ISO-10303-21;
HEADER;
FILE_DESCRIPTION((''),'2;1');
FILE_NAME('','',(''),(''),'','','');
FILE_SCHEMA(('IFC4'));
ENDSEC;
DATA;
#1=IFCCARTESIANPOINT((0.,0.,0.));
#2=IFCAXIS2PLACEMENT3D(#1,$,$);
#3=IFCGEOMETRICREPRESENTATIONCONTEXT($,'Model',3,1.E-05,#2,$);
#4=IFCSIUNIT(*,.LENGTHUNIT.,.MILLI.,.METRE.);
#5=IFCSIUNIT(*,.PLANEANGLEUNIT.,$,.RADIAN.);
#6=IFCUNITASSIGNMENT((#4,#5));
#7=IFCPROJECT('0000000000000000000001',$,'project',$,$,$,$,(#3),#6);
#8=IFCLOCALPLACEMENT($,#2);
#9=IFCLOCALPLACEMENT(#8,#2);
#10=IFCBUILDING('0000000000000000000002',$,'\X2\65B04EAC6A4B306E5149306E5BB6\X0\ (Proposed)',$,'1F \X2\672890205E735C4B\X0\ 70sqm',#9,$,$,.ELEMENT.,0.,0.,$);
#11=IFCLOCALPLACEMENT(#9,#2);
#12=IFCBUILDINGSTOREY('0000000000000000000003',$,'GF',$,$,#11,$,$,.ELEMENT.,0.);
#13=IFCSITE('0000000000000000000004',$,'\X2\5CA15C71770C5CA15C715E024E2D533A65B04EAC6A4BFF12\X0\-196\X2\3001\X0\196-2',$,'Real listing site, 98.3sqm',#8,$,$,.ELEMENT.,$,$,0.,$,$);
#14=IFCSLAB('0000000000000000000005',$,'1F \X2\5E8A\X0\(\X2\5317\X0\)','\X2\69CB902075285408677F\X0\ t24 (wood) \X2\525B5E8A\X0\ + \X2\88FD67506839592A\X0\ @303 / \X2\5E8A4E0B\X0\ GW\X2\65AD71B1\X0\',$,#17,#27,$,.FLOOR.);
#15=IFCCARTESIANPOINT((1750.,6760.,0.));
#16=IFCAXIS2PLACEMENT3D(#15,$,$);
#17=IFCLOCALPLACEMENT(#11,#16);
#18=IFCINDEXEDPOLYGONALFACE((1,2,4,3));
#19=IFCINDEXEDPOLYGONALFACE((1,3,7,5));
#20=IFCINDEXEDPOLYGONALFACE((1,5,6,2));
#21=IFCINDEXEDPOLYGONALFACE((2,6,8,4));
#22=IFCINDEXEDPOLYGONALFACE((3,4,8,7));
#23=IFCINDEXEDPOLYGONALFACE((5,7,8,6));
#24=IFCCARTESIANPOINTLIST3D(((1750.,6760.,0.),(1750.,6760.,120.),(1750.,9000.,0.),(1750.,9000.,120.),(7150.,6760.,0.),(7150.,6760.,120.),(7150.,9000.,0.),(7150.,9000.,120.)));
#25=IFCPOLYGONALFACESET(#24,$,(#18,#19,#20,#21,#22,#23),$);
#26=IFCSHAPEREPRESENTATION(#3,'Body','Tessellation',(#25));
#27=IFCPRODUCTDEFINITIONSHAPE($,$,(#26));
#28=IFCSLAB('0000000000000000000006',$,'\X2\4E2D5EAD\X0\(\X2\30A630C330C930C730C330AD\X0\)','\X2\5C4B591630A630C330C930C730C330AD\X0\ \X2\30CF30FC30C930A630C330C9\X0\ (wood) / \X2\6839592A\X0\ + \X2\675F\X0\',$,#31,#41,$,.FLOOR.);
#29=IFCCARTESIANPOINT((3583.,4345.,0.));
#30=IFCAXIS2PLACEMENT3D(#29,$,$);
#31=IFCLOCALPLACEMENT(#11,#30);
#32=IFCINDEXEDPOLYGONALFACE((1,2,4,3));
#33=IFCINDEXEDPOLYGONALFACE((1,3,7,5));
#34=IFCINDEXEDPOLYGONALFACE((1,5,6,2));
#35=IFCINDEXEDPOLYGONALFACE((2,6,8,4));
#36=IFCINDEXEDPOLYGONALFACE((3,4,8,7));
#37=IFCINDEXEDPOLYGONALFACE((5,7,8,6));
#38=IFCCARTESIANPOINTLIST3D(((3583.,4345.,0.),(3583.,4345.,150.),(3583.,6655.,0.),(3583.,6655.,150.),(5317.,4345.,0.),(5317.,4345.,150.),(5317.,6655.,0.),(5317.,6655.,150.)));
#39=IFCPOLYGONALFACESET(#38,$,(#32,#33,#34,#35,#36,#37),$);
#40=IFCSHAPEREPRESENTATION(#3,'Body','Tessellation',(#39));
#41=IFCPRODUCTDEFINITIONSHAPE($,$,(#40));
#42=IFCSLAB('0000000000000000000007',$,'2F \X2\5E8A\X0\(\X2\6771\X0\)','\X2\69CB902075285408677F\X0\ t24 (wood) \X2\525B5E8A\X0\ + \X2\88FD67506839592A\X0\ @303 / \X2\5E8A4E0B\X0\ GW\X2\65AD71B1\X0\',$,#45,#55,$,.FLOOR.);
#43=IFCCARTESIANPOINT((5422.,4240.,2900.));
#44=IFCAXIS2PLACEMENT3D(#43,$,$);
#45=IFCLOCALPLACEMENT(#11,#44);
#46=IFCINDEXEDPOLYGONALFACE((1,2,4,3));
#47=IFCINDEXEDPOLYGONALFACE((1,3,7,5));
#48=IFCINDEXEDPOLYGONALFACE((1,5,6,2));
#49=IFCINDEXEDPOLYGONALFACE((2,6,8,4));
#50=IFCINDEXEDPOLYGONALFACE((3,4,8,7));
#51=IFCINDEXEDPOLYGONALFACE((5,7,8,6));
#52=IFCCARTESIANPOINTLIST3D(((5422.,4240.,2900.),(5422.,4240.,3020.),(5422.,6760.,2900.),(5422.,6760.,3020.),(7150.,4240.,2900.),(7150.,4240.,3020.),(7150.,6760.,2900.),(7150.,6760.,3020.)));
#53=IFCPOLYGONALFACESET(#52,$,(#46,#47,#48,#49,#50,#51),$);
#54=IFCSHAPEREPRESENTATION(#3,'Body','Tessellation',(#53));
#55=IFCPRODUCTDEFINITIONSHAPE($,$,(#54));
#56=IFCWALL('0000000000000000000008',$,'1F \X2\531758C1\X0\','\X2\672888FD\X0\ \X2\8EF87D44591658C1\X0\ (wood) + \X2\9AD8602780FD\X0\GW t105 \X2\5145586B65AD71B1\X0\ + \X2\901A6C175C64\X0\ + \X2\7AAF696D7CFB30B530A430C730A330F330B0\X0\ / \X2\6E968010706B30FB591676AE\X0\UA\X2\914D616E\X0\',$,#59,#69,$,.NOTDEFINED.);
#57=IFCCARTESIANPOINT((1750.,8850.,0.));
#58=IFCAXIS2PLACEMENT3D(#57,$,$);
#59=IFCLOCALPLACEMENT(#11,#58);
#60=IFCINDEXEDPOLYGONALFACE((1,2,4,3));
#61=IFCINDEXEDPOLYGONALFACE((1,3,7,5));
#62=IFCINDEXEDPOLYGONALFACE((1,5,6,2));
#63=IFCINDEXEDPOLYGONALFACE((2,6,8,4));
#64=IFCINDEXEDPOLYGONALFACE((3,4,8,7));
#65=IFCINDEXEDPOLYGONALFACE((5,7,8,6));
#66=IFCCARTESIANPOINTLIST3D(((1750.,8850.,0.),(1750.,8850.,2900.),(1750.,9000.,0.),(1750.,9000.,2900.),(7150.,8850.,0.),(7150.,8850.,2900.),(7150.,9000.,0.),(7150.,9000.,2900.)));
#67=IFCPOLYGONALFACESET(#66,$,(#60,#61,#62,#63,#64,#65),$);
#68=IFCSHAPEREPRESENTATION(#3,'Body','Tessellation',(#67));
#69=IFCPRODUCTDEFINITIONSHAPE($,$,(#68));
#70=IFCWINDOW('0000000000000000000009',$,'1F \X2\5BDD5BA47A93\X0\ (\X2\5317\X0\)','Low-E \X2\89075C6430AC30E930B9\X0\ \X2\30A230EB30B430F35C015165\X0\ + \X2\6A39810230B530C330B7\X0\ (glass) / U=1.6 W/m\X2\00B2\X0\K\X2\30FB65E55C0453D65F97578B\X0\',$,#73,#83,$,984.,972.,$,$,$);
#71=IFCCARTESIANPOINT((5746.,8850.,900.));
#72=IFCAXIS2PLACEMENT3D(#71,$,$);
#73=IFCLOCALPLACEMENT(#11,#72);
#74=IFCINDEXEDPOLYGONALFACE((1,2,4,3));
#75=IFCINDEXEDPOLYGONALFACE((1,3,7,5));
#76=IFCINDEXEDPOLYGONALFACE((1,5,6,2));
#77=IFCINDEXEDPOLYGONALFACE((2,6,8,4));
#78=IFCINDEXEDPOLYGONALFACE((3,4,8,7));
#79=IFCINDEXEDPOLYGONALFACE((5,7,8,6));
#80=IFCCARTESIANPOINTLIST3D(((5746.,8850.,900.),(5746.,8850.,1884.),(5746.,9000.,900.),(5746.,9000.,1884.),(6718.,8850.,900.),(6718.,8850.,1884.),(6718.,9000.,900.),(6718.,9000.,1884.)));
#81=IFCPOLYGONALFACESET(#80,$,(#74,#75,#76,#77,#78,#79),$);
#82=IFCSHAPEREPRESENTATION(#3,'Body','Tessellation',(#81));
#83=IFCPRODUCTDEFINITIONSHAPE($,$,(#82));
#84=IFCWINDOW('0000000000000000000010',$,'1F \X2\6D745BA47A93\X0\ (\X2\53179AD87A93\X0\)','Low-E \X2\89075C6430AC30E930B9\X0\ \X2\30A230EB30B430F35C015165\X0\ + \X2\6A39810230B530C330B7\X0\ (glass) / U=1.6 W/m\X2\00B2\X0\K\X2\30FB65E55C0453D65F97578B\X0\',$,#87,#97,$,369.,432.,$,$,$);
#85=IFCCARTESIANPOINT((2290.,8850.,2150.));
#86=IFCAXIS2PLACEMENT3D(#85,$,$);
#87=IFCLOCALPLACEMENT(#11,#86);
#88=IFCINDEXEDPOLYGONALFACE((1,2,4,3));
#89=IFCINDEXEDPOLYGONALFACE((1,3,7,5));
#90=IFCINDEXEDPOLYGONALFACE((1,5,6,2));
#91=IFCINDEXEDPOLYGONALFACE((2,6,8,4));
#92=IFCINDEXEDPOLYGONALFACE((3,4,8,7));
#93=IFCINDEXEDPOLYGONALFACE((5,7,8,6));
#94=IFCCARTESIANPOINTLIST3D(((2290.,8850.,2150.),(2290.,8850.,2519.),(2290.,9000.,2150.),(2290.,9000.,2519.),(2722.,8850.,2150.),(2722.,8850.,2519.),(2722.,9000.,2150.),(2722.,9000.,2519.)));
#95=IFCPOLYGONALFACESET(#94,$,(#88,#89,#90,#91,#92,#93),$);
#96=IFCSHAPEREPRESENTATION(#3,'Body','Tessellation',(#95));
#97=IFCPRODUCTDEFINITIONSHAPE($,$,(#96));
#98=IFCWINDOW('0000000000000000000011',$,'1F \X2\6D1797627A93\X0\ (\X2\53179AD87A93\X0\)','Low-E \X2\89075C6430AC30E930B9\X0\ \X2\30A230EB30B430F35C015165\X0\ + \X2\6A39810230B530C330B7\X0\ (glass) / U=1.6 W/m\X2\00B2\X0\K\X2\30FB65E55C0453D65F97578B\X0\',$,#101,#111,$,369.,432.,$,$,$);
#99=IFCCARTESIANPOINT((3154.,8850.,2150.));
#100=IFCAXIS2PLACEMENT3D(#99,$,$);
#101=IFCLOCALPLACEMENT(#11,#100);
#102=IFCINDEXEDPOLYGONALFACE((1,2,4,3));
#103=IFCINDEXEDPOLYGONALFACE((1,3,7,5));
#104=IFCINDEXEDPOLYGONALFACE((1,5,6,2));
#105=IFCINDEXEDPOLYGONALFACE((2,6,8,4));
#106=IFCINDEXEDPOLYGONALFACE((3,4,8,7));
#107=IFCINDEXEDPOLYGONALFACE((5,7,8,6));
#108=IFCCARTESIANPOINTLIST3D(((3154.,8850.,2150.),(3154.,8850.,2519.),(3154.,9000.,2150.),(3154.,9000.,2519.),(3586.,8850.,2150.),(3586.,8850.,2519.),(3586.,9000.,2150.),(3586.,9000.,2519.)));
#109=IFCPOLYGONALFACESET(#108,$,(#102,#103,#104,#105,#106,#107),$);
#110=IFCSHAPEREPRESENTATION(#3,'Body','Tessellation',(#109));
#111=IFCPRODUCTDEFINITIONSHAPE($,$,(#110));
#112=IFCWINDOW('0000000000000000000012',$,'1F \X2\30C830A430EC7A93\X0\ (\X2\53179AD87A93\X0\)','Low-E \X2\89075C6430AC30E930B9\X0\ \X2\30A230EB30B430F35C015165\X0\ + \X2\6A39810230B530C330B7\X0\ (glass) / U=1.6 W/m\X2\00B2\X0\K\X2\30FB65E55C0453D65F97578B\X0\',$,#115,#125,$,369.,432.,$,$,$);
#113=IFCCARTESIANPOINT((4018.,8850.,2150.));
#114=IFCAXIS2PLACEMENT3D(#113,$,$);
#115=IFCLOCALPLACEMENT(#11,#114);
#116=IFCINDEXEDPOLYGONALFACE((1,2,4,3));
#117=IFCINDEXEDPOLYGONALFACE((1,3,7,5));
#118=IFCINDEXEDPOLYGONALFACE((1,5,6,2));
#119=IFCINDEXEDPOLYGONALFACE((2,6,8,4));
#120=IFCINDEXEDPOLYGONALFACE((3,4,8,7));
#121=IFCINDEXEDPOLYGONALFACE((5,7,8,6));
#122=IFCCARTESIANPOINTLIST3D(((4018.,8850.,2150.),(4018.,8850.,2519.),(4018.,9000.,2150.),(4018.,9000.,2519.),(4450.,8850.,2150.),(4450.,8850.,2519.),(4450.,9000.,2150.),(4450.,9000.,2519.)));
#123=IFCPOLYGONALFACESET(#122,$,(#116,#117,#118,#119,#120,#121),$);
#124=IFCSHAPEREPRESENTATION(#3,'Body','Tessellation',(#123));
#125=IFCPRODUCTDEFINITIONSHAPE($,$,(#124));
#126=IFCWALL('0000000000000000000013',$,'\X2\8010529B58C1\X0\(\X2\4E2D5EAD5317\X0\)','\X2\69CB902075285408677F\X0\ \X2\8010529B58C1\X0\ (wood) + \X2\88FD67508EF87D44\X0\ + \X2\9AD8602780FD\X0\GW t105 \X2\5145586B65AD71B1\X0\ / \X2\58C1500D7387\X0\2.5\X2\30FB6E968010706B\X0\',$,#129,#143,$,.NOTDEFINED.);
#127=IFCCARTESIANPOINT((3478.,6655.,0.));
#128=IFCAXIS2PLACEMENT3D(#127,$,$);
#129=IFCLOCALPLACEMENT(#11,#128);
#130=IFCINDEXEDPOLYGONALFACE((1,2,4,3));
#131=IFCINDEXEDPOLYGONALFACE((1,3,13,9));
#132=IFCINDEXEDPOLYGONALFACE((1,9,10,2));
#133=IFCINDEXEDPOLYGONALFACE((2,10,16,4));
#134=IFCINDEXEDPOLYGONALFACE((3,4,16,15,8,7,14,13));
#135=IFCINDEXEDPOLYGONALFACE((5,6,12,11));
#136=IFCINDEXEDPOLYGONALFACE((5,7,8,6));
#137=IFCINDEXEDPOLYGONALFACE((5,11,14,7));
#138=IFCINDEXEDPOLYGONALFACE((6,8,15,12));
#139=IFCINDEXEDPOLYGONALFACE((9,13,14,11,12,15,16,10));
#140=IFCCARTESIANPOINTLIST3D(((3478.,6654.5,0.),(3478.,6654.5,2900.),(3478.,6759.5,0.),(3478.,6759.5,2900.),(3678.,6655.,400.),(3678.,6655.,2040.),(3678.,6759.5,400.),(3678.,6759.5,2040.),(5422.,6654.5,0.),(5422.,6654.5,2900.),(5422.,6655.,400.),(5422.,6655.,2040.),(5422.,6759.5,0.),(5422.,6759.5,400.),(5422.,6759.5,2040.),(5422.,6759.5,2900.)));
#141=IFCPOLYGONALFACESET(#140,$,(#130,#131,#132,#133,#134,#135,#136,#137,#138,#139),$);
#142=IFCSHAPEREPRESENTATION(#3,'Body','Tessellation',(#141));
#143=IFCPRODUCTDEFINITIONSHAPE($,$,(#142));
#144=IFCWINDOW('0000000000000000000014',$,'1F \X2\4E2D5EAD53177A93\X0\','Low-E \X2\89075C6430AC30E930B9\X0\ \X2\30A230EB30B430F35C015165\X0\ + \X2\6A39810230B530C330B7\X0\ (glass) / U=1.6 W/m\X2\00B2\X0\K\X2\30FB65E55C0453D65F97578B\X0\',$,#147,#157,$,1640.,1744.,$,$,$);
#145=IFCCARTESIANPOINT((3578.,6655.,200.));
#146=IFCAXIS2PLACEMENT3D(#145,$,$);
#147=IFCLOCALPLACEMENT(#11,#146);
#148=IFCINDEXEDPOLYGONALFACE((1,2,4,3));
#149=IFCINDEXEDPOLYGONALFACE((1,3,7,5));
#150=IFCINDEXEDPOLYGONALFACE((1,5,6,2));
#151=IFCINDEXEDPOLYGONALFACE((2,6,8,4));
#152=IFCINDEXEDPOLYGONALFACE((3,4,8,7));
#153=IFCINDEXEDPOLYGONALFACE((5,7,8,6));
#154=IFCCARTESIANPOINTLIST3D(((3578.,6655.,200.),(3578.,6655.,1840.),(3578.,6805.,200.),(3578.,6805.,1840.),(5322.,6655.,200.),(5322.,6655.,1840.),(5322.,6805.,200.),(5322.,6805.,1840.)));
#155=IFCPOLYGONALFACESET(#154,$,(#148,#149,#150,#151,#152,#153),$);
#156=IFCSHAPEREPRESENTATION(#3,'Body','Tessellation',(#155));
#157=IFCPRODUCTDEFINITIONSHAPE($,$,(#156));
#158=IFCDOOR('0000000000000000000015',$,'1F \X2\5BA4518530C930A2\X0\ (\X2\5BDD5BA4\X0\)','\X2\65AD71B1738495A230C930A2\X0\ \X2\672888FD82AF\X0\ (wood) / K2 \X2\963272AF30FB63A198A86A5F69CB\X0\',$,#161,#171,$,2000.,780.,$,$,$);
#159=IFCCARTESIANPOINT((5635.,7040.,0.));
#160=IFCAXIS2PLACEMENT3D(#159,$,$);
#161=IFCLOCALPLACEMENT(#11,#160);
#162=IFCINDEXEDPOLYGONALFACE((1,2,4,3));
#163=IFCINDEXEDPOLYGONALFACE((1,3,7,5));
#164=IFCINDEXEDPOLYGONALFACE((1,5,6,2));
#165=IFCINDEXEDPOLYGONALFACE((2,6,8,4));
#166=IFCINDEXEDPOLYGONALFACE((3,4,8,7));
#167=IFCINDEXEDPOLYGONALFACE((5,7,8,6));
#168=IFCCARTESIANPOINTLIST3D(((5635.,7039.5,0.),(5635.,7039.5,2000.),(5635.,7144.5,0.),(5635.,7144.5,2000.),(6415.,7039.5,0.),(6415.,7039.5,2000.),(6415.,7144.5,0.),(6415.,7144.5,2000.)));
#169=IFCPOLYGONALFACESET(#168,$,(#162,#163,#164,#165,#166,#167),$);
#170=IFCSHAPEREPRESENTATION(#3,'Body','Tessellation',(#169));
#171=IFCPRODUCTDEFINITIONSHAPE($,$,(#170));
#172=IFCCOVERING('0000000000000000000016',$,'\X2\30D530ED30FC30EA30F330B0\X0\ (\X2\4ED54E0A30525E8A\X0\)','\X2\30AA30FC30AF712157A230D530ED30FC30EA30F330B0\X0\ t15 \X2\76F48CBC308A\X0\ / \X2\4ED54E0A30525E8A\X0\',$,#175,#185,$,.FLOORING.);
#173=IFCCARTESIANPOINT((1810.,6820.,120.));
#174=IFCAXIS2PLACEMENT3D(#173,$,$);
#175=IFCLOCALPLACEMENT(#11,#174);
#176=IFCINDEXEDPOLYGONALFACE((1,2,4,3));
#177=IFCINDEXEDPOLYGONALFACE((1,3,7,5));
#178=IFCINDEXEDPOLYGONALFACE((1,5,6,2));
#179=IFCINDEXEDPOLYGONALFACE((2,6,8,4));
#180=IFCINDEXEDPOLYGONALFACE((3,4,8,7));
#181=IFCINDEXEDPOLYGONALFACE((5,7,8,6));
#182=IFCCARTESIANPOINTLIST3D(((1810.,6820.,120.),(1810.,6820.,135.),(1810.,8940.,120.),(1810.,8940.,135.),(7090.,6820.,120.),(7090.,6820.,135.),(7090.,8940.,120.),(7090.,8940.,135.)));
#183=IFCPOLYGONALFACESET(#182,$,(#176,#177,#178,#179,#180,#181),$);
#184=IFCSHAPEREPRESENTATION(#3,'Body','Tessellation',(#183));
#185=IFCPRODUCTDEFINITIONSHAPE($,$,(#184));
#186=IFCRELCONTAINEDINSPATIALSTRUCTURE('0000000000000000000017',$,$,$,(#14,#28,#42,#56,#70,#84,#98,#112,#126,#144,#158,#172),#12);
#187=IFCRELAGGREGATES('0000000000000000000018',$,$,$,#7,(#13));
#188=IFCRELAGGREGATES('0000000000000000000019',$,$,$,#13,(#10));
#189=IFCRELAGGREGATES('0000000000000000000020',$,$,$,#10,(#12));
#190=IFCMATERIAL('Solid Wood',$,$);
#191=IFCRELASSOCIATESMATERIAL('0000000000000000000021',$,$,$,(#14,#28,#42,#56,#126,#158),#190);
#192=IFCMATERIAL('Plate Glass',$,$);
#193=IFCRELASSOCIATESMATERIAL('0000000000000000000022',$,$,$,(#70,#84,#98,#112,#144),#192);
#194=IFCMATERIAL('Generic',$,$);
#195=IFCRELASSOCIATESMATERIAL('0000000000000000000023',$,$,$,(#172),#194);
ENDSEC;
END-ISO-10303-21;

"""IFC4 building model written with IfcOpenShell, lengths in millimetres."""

from ifc_helpers import new_model, si_unit, frame, frame_2d, origin, place, context, project, spatial, rectangle, extrude, material, element, fill, save


model = new_model("IFC4")

# Units and contexts
model_context = context("Model", 3, precision=1e-05, world=origin())
ifc_project = project(units=[si_unit("LENGTHUNIT", "METRE", prefix="MILLI"), si_unit("PLANEANGLEUNIT", "RADIAN")], contexts=[model_context])

# Site, building, storey
site_placement = place(None, origin())
site = spatial("IfcSite", under=ifc_project, at=site_placement, Name="岡山県岡山市中区新京橋２-196、196-2", ObjectType="Real listing site, 98.3sqm", CompositionType="ELEMENT", RefElevation=0.0)
building_placement = place(site_placement, origin())
building = spatial("IfcBuilding", under=site, at=building_placement, Name="新京橋の光の家 (Proposed)", ObjectType="1F 木造平屋 70sqm", CompositionType="ELEMENT", ElevationOfRefHeight=0.0, ElevationOfTerrain=0.0)
storey_placement = place(building_placement, origin())
storey = spatial("IfcBuildingStorey", under=building, at=storey_placement, Name="GF", CompositionType="ELEMENT", Elevation=0.0)

# Slabs
ifc_material_1 = material(Name="Solid Wood")
slab_1_placement = place(storey_placement, frame((1750.0, 6760.0, 0.0)))
element("IfcSlab", 1, at=slab_1_placement, inside=storey, material=ifc_material_1, Name="1F 床(北)", Description="構造用合板 t24 (wood) 剛床 + 製材根太 @303 / 床下 GW断熱", PredefinedType="FLOOR", context=model_context, shape_type="SweptSolid", body=[
    extrude(rectangle(XDim=5400.0, YDim=2240.0, at=frame_2d((2700.0, 1120.0))), frame((1750.0, 6760.0, 0.0)), (0.0, 0.0, 1.0), 120.0),
])
slab_2_placement = place(storey_placement, frame((3583.0, 4345.0, 0.0)))
element("IfcSlab", 2, at=slab_2_placement, inside=storey, material=ifc_material_1, Name="中庭(ウッドデッキ)", Description="屋外ウッドデッキ ハードウッド (wood) / 根太 + 束", PredefinedType="FLOOR", context=model_context, shape_type="SweptSolid", body=[
    extrude(rectangle(XDim=1734.0, YDim=2310.0, at=frame_2d((867.0, 1155.0))), frame((3583.0, 4345.0, 0.0)), (0.0, 0.0, 1.0), 150.0),
])
slab_3_placement = place(storey_placement, frame((5422.0, 4240.0, 2900.0)))
element("IfcSlab", 3, at=slab_3_placement, inside=storey, material=ifc_material_1, Name="2F 床(東)", Description="構造用合板 t24 (wood) 剛床 + 製材根太 @303 / 床下 GW断熱", PredefinedType="FLOOR", context=model_context, shape_type="SweptSolid", body=[
    extrude(rectangle(XDim=1728.0, YDim=2520.0, at=frame_2d((864.0, 1260.0))), frame((5422.0, 4240.0, 2900.0)), (0.0, 0.0, 1.0), 120.0),
])

# Wall, openings, windows
wall_1_placement = place(storey_placement, frame((1750.0, 8850.0, 0.0)))
wall_1 = element("IfcWall", 4, at=wall_1_placement, inside=storey, material=ifc_material_1, Name="1F 北壁", Description="木製 軸組外壁 (wood) + 高性能GW t105 充填断熱 + 通気層 + 窯業系サイディング / 準耐火・外皮UA配慮", PredefinedType="NOTDEFINED", context=model_context, shape_type="SweptSolid", body=[
    extrude(rectangle(XDim=5400.0, YDim=150.0, at=frame_2d((2700.0, 75.0))), frame((1750.0, 8850.0, 0.0)), (0.0, 0.0, 1.0), 2900.0),
])
opening_1_placement = place(storey_placement, frame((5746.0, 8850.0, 900.0)))
opening_1 = element("IfcOpeningElement", 5, at=opening_1_placement, cuts=wall_1, PredefinedType="NOTDEFINED", context=model_context, shape_type="SweptSolid", body=[
    extrude(rectangle(XDim=972.0, YDim=150.0, at=frame_2d((486.0, 75.0))), frame((5746.0, 8850.0, 900.0)), (0.0, 0.0, 1.0), 984.0),
])
opening_2_placement = place(storey_placement, frame((2290.0, 8850.0, 2150.0)))
opening_2 = element("IfcOpeningElement", 6, at=opening_2_placement, cuts=wall_1, PredefinedType="NOTDEFINED", context=model_context, shape_type="SweptSolid", body=[
    extrude(rectangle(XDim=432.0, YDim=150.0, at=frame_2d((216.0, 75.0))), frame((2290.0, 8850.0, 2150.0)), (0.0, 0.0, 1.0), 369.0),
])
opening_3_placement = place(storey_placement, frame((3154.0, 8850.0, 2150.0)))
opening_3 = element("IfcOpeningElement", 7, at=opening_3_placement, cuts=wall_1, PredefinedType="NOTDEFINED", context=model_context, shape_type="SweptSolid", body=[
    extrude(rectangle(XDim=432.0, YDim=150.0, at=frame_2d((216.0, 75.0))), frame((3154.0, 8850.0, 2150.0)), (0.0, 0.0, 1.0), 369.0),
])
opening_4_placement = place(storey_placement, frame((4018.0, 8850.0, 2150.0)))
opening_4 = element("IfcOpeningElement", 8, at=opening_4_placement, cuts=wall_1, PredefinedType="NOTDEFINED", context=model_context, shape_type="SweptSolid", body=[
    extrude(rectangle(XDim=432.0, YDim=150.0, at=frame_2d((216.0, 75.0))), frame((4018.0, 8850.0, 2150.0)), (0.0, 0.0, 1.0), 369.0),
])
ifc_material_2 = material(Name="Plate Glass")
window_1_placement = place(storey_placement, frame((5746.0, 8850.0, 900.0)))
window_1 = element("IfcWindow", 9, at=window_1_placement, inside=storey, material=ifc_material_2, Name="1F 寝室窓 (北)", Description="Low-E 複層ガラス アルゴン封入 + 樹脂サッシ (glass) / U=1.6 W/m²K・日射取得型", OverallHeight=984.0, OverallWidth=972.0, context=model_context, shape_type="SweptSolid", body=[
    extrude(rectangle(XDim=972.0, YDim=150.0, at=frame_2d((486.0, 75.0))), frame((5746.0, 8850.0, 900.0)), (0.0, 0.0, 1.0), 984.0),
])
fill(opening_1, window_1)
window_2_placement = place(storey_placement, frame((2290.0, 8850.0, 2150.0)))
window_2 = element("IfcWindow", 10, at=window_2_placement, inside=storey, material=ifc_material_2, Name="1F 浴室窓 (北高窓)", Description="Low-E 複層ガラス アルゴン封入 + 樹脂サッシ (glass) / U=1.6 W/m²K・日射取得型", OverallHeight=369.0, OverallWidth=432.0, context=model_context, shape_type="SweptSolid", body=[
    extrude(rectangle(XDim=432.0, YDim=150.0, at=frame_2d((216.0, 75.0))), frame((2290.0, 8850.0, 2150.0)), (0.0, 0.0, 1.0), 369.0),
])
fill(opening_2, window_2)
window_3_placement = place(storey_placement, frame((3154.0, 8850.0, 2150.0)))
window_3 = element("IfcWindow", 11, at=window_3_placement, inside=storey, material=ifc_material_2, Name="1F 洗面窓 (北高窓)", Description="Low-E 複層ガラス アルゴン封入 + 樹脂サッシ (glass) / U=1.6 W/m²K・日射取得型", OverallHeight=369.0, OverallWidth=432.0, context=model_context, shape_type="SweptSolid", body=[
    extrude(rectangle(XDim=432.0, YDim=150.0, at=frame_2d((216.0, 75.0))), frame((3154.0, 8850.0, 2150.0)), (0.0, 0.0, 1.0), 369.0),
])
fill(opening_3, window_3)
window_4_placement = place(storey_placement, frame((4018.0, 8850.0, 2150.0)))
window_4 = element("IfcWindow", 12, at=window_4_placement, inside=storey, material=ifc_material_2, Name="1F トイレ窓 (北高窓)", Description="Low-E 複層ガラス アルゴン封入 + 樹脂サッシ (glass) / U=1.6 W/m²K・日射取得型", OverallHeight=369.0, OverallWidth=432.0, context=model_context, shape_type="SweptSolid", body=[
    extrude(rectangle(XDim=432.0, YDim=150.0, at=frame_2d((216.0, 75.0))), frame((4018.0, 8850.0, 2150.0)), (0.0, 0.0, 1.0), 369.0),
])
fill(opening_4, window_4)

# Wall, opening, window
wall_2_placement = place(storey_placement, frame((3478.0, 6655.0, 0.0)))
wall_2 = element("IfcWall", 13, at=wall_2_placement, inside=storey, material=ifc_material_1, Name="耐力壁(中庭北)", Description="構造用合板 耐力壁 (wood) + 製材軸組 + 高性能GW t105 充填断熱 / 壁倍率2.5・準耐火", PredefinedType="NOTDEFINED", context=model_context, shape_type="SweptSolid", body=[
    extrude(rectangle(XDim=1944.0, YDim=105.0, at=frame_2d((972.0, 52.0))), frame((3478.0, 6655.0, 0.0)), (0.0, 0.0, 1.0), 2900.0),
])
opening_5_placement = place(storey_placement, frame((3578.0, 6655.0, 200.0)))
opening_5 = element("IfcOpeningElement", 14, at=opening_5_placement, cuts=wall_2, PredefinedType="NOTDEFINED", context=model_context, shape_type="SweptSolid", body=[
    extrude(rectangle(XDim=1744.0, YDim=150.0, at=frame_2d((872.0, 75.0))), frame((3578.0, 6655.0, 200.0)), (0.0, 0.0, 1.0), 1640.0),
])
window_5_placement = place(storey_placement, frame((3578.0, 6655.0, 200.0)))
window_5 = element("IfcWindow", 15, at=window_5_placement, inside=storey, material=ifc_material_2, Name="1F 中庭北窓", Description="Low-E 複層ガラス アルゴン封入 + 樹脂サッシ (glass) / U=1.6 W/m²K・日射取得型", OverallHeight=1640.0, OverallWidth=1744.0, context=model_context, shape_type="SweptSolid", body=[
    extrude(rectangle(XDim=1744.0, YDim=150.0, at=frame_2d((872.0, 75.0))), frame((3578.0, 6655.0, 200.0)), (0.0, 0.0, 1.0), 1640.0),
])
fill(opening_5, window_5)

# Door
door_1_placement = place(storey_placement, frame((5635.0, 7040.0, 0.0)))
element("IfcDoor", 16, at=door_1_placement, inside=storey, material=ifc_material_1, Name="1F 室内ドア (寝室)", Description="断熱玄関ドア 木製芯 (wood) / K2 防犯・採風機構", OverallHeight=2000.0, OverallWidth=780.0, context=model_context, shape_type="SweptSolid", body=[
    extrude(rectangle(XDim=780.0, YDim=105.0, at=frame_2d((390.0, 52.0))), frame((5635.0, 7040.0, 0.0)), (0.0, 0.0, 1.0), 2000.0),
])

# Covering
ifc_material_3 = material(Name="Generic")
covering_1_placement = place(storey_placement, frame((1810.0, 6820.0, 120.0)))
element("IfcCovering", 17, at=covering_1_placement, inside=storey, material=ifc_material_3, Name="フローリング (仕上げ床)", Description="オーク無垢フローリング t15 直貼り / 仕上げ床", PredefinedType="FLOORING", context=model_context, shape_type="SweptSolid", body=[
    extrude(rectangle(XDim=5280.0, YDim=2120.0, at=frame_2d((2640.0, 1060.0))), frame((1810.0, 6820.0, 120.0)), (0.0, 0.0, 1.0), 15.0),
])

save(model, "model.ifc")
